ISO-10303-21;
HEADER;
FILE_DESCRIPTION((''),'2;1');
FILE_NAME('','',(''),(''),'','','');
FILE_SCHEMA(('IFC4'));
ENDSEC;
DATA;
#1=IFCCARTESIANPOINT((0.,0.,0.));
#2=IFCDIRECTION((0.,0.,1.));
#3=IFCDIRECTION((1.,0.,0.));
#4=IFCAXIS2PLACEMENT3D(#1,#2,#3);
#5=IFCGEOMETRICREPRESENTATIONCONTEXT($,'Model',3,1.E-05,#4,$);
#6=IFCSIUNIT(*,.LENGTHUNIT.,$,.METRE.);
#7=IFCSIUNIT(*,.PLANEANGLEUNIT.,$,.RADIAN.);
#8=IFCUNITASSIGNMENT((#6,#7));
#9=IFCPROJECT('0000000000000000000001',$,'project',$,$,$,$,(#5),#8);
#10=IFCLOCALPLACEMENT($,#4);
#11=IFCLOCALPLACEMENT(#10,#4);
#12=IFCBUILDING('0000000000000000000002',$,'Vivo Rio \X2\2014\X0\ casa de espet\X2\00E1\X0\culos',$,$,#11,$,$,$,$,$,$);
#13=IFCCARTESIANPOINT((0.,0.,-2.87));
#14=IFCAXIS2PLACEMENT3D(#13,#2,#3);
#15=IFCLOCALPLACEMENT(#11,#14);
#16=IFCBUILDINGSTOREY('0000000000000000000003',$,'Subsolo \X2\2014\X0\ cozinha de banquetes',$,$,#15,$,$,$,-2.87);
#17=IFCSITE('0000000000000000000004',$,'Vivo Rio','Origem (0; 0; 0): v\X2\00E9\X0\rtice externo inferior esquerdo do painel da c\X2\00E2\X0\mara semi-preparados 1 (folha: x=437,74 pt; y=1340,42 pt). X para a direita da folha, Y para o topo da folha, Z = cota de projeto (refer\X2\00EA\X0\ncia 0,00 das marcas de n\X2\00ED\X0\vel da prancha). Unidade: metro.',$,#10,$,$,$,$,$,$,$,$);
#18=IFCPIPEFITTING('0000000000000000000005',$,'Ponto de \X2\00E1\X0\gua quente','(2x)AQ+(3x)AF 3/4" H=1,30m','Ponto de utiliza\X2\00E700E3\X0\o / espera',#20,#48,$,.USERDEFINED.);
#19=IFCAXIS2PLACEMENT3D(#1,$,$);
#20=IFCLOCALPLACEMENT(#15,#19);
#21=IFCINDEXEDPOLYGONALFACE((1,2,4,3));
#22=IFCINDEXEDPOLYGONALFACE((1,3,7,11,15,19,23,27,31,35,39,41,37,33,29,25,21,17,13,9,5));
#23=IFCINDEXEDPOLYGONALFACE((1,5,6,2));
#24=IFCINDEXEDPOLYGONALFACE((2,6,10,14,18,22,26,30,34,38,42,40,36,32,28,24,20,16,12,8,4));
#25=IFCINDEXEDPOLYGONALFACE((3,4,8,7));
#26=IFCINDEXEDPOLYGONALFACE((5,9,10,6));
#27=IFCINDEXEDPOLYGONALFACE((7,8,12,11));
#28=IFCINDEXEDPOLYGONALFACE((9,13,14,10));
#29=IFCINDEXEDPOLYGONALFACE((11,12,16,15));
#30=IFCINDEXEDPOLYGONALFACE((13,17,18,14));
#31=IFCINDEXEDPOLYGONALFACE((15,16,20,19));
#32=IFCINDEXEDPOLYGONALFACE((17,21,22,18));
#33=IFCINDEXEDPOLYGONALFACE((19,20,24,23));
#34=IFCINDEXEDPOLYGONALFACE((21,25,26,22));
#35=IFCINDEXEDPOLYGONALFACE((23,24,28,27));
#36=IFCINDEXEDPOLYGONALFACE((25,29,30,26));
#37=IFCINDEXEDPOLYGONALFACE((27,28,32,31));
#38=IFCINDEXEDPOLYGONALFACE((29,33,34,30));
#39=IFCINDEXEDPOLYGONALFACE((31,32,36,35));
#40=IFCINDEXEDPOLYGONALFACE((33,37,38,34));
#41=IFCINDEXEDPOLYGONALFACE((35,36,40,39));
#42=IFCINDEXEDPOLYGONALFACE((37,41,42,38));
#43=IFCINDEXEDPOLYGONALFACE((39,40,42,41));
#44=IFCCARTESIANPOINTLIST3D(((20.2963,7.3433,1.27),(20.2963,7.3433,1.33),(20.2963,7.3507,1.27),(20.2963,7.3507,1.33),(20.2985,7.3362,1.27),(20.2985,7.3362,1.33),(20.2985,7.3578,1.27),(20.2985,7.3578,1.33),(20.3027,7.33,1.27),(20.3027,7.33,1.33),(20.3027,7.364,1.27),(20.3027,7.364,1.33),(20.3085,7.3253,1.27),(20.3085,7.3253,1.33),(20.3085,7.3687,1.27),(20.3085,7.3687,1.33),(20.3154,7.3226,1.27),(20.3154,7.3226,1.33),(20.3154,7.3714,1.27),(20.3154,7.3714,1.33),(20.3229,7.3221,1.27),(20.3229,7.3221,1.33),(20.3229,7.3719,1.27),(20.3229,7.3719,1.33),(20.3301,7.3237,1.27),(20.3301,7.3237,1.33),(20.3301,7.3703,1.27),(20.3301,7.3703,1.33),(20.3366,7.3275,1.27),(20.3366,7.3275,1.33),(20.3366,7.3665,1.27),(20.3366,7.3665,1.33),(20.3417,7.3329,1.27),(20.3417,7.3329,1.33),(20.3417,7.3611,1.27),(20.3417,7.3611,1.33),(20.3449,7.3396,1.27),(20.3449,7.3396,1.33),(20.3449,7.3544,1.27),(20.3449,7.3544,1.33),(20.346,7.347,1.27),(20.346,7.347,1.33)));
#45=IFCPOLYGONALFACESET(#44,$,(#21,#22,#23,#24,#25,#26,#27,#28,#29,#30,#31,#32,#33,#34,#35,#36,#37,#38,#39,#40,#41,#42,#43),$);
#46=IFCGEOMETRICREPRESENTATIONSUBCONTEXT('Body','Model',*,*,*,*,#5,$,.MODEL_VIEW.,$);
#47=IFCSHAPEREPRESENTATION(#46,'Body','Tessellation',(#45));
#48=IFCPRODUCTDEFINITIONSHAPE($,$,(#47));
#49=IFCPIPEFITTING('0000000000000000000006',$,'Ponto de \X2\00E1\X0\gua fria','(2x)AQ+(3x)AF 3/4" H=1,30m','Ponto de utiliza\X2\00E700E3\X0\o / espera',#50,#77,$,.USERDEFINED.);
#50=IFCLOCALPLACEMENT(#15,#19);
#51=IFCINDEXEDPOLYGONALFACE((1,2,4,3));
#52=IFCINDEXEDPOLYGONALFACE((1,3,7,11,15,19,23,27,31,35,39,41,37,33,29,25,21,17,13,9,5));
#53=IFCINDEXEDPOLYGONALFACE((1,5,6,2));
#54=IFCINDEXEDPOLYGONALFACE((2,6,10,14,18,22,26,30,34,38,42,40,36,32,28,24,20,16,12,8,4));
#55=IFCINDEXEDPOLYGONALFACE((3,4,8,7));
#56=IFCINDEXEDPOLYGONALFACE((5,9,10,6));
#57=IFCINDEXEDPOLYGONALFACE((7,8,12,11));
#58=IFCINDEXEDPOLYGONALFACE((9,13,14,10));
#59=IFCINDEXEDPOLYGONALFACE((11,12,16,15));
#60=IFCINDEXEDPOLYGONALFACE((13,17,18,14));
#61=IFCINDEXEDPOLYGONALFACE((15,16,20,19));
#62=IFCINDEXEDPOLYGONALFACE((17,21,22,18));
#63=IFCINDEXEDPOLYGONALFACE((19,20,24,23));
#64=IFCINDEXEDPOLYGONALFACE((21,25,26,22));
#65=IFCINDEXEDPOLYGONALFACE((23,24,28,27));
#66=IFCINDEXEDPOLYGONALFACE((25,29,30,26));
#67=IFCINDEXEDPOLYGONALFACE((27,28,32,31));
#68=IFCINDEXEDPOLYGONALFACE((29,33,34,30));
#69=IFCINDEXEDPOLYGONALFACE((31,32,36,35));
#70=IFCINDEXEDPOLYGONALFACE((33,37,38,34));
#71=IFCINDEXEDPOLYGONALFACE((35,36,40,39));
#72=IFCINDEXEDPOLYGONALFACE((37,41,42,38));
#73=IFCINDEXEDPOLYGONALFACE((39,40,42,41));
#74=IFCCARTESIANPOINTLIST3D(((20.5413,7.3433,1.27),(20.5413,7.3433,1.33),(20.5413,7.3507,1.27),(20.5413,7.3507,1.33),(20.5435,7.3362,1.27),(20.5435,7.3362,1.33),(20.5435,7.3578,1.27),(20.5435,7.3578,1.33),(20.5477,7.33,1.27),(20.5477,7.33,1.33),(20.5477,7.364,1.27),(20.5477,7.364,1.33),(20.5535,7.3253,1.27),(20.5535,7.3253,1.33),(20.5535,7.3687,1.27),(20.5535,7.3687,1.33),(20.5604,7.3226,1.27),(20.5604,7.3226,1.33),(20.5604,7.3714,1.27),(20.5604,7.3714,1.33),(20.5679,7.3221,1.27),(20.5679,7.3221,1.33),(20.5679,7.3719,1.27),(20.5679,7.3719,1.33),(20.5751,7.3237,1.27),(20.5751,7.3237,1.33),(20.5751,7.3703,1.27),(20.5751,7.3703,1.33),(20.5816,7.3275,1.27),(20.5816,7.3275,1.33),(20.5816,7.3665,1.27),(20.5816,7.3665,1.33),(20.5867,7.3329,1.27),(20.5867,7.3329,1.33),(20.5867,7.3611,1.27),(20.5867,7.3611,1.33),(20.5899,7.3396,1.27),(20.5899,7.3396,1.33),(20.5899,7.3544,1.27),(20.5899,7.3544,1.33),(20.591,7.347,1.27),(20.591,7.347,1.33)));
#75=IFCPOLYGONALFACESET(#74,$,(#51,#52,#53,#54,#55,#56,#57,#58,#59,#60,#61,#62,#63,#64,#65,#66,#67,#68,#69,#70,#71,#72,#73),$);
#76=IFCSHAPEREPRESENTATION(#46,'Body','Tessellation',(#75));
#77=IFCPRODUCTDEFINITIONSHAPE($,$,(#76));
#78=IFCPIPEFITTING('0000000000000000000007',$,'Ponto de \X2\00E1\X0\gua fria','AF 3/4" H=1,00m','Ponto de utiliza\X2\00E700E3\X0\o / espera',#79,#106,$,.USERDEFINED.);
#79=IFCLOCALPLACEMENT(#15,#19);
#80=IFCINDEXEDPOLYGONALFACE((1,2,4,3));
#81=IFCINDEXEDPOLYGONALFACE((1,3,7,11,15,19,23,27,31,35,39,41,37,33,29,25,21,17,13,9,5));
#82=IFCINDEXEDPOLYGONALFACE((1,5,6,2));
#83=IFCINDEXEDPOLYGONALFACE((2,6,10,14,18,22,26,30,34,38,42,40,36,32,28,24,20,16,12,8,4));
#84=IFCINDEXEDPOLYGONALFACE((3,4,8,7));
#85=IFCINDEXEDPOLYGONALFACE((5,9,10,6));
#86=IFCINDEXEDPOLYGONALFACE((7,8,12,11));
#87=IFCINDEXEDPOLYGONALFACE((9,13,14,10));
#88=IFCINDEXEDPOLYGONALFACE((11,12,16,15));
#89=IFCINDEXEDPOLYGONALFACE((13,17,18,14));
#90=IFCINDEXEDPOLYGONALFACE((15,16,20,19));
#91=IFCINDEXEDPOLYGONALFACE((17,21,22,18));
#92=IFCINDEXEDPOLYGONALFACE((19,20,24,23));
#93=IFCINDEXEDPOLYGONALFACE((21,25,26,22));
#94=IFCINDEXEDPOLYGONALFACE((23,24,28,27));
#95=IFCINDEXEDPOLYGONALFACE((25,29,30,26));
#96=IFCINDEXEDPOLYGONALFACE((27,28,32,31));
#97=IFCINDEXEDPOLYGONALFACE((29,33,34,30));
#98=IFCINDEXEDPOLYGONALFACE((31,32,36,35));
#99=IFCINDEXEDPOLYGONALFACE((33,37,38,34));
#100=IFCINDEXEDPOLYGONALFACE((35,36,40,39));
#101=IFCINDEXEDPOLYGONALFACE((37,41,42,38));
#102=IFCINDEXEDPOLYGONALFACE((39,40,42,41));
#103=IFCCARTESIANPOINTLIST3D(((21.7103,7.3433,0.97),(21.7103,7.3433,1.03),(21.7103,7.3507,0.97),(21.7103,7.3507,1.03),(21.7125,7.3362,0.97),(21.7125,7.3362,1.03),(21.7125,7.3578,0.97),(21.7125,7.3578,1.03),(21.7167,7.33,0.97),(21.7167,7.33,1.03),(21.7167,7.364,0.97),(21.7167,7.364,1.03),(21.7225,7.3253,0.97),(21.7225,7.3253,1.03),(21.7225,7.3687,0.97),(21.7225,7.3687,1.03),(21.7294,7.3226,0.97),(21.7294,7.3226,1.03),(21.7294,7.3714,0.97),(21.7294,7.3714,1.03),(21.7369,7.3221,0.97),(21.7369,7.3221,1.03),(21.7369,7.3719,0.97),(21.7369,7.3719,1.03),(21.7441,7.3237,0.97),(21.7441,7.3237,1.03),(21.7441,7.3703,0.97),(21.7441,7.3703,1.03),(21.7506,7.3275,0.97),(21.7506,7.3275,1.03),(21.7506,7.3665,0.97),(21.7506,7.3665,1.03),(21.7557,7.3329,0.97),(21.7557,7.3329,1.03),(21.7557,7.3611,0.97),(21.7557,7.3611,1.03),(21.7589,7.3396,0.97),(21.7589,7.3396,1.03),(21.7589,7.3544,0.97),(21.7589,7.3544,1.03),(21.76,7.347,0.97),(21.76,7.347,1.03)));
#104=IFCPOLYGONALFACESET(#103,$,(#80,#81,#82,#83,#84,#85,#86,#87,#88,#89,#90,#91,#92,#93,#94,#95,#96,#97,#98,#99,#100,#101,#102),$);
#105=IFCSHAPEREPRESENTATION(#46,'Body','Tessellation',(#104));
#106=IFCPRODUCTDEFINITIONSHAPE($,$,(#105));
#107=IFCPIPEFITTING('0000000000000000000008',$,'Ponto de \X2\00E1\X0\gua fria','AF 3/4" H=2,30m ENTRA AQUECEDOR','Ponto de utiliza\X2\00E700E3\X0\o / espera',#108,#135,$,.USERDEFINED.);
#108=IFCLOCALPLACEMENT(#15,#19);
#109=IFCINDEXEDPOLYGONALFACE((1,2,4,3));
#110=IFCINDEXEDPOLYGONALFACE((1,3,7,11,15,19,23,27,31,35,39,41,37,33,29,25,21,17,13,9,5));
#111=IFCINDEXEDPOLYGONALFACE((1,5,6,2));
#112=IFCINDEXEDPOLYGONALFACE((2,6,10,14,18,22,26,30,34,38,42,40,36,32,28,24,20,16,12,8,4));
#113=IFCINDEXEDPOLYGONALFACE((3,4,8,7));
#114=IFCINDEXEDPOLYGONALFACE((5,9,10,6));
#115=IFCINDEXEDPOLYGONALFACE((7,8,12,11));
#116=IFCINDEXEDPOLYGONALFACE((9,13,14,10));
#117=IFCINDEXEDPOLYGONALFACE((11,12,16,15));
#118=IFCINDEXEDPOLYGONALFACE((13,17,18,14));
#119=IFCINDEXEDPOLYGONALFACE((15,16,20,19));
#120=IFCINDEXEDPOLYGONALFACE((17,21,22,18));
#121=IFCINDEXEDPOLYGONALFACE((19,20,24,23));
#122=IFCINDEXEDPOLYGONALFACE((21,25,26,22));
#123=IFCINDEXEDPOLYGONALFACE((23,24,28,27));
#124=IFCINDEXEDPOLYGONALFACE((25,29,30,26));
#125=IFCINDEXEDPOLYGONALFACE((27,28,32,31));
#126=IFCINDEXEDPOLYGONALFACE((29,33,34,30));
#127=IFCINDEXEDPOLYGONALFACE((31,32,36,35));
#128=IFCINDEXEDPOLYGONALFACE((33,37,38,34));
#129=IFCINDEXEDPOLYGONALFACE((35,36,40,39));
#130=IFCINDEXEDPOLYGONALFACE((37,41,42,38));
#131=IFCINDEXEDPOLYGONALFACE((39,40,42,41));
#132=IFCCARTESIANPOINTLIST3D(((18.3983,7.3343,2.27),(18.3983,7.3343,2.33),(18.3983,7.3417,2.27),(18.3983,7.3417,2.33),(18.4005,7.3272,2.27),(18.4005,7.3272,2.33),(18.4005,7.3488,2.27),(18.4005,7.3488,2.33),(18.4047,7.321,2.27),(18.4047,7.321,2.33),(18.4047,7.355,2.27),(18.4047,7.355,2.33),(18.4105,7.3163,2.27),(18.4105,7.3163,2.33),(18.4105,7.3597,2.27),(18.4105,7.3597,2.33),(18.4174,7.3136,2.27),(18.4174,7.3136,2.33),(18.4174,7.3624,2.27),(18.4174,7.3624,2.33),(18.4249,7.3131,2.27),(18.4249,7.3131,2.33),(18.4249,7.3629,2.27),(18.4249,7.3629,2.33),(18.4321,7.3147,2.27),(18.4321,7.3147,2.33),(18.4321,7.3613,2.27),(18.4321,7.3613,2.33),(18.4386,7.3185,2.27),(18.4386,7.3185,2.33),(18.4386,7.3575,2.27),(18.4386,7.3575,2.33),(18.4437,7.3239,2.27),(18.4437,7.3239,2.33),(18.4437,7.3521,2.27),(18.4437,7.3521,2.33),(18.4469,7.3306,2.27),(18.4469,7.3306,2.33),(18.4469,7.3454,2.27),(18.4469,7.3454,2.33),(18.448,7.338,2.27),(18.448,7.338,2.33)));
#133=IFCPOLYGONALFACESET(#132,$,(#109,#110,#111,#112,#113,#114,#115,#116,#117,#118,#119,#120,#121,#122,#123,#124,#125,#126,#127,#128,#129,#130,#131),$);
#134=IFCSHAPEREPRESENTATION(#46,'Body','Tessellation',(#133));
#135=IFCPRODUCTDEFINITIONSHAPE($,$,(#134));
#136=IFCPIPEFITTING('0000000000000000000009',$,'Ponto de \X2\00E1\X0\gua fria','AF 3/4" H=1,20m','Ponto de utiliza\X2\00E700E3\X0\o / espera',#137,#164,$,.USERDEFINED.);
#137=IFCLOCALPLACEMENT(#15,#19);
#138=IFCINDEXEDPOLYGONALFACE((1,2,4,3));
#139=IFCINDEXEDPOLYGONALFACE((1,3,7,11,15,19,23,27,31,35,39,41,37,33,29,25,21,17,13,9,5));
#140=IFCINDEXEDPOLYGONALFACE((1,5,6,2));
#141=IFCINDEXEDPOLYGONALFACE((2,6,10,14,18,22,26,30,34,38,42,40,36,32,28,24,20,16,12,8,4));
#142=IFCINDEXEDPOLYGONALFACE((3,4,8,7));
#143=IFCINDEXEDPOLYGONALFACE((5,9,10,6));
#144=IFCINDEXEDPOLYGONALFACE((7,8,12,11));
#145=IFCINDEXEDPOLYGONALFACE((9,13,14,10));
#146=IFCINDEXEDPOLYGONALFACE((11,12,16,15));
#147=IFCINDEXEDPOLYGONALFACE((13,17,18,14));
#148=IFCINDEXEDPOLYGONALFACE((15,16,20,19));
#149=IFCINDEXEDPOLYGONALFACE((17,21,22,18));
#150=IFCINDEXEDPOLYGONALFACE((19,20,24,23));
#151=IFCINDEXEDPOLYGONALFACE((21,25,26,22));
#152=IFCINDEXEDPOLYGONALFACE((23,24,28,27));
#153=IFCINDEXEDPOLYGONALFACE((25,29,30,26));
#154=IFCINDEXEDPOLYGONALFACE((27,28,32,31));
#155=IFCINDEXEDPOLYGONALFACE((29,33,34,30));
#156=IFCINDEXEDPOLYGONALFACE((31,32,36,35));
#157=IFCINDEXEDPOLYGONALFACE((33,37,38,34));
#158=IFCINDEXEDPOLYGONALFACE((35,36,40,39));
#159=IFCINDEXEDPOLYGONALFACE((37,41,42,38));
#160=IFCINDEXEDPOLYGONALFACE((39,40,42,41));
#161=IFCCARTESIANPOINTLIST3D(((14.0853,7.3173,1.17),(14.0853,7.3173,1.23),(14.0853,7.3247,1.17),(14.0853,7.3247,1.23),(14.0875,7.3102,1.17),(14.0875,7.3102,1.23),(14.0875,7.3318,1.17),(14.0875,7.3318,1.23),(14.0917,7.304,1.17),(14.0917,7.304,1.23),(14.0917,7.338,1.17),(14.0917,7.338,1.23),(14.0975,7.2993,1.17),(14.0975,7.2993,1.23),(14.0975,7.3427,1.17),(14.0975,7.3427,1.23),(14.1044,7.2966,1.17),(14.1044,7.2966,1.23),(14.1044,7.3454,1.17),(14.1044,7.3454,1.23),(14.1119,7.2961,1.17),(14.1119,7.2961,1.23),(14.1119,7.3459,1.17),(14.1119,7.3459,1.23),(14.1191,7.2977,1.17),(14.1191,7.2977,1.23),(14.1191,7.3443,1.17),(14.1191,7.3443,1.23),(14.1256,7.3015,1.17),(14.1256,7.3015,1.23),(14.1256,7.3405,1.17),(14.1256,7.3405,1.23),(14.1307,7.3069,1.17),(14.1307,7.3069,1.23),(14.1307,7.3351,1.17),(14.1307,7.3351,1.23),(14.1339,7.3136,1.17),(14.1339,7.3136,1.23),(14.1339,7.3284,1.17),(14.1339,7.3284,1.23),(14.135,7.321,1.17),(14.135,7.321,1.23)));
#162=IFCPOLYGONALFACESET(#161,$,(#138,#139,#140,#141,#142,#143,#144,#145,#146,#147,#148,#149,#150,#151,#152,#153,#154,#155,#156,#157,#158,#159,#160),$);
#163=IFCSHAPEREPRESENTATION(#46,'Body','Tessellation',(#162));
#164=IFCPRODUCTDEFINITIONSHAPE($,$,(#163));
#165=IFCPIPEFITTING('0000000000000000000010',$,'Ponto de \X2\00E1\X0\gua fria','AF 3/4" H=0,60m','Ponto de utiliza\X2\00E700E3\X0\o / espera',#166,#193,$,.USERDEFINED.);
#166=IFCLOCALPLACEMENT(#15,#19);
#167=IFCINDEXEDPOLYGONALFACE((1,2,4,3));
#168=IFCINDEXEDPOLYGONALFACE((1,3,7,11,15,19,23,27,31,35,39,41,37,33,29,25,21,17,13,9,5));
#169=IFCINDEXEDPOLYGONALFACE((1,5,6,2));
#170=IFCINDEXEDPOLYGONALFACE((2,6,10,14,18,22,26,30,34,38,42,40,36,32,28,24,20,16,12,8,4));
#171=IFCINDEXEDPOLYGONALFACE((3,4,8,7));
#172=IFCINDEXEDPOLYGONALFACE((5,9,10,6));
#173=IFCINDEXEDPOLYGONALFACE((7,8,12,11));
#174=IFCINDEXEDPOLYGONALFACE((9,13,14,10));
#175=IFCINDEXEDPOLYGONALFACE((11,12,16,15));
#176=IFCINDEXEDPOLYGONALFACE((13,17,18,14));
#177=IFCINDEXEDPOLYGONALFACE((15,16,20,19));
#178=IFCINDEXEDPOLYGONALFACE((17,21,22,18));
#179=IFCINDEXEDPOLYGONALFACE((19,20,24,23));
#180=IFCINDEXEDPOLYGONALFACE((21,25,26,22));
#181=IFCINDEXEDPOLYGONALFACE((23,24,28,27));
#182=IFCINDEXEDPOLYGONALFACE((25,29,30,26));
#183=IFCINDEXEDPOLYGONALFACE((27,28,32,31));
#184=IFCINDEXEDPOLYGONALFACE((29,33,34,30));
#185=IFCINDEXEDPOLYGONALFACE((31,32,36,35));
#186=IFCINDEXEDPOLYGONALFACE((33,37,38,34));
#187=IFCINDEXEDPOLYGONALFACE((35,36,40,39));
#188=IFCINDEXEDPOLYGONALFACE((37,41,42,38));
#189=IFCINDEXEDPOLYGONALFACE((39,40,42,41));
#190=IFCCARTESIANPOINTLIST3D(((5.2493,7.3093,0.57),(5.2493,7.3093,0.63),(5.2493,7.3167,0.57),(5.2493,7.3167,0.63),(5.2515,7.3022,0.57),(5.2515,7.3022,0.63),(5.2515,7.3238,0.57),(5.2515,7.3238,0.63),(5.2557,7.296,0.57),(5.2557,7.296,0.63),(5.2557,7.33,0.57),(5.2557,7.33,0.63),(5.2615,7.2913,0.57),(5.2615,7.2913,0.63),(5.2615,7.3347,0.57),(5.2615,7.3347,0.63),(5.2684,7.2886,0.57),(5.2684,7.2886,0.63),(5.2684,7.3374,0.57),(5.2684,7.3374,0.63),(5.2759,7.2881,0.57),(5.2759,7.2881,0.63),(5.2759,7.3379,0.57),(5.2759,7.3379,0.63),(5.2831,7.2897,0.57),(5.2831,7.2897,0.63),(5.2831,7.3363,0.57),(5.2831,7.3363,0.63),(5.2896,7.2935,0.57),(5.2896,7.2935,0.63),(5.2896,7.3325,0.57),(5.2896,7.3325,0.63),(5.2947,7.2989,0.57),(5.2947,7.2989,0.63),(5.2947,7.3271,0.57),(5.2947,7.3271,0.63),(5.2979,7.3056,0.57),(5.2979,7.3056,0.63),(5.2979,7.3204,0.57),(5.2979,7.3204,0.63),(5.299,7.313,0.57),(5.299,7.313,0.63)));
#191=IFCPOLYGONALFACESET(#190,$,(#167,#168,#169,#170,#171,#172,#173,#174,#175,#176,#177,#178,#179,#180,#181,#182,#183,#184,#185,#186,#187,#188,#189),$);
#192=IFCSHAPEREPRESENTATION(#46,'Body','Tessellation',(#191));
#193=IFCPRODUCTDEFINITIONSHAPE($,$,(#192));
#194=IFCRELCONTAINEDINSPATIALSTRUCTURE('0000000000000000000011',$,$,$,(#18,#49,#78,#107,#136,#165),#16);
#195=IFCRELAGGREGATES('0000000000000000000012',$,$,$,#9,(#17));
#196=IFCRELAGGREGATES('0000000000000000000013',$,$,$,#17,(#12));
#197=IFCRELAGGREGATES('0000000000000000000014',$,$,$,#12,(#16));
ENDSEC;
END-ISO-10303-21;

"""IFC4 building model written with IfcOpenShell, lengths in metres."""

from ifc_helpers import new_model, si_unit, frame, origin_with_axes, origin_2d, place, context, subcontext, project, spatial, circle, extrude, element, save


model = new_model("IFC4")

# Units and contexts
model_context = context("Model", 3, precision=1e-05, world=origin_with_axes())
body_context = subcontext(model_context, "Body", "Model", "MODEL_VIEW")
ifc_project = project(units=[si_unit("LENGTHUNIT", "METRE"), si_unit("PLANEANGLEUNIT", "RADIAN")], contexts=[model_context])

# Site, building, storey
site_placement = place(None, origin_with_axes())
site = spatial("IfcSite", under=ifc_project, at=site_placement, Name="Vivo Rio", Description="Origem (0; 0; 0): vértice externo inferior esquerdo do painel da câmara semi-preparados 1 (folha: x=437,74 pt; y=1340,42 pt). X para a direita da folha, Y para o topo da folha, Z = cota de projeto (referência 0,00 das marcas de nível da prancha). Unidade: metro.")
building_placement = place(site_placement, origin_with_axes())
building = spatial("IfcBuilding", under=site, at=building_placement, Name="Vivo Rio — casa de espetáculos")
storey_placement = place(building_placement, frame((0.0, 0.0, -2.87), z_axis=(0.0, 0.0, 1.0), x_axis=(1.0, 0.0, 0.0)))
storey = spatial("IfcBuildingStorey", under=building, at=storey_placement, Name="Subsolo — cozinha de banquetes", Elevation=-2.87)

# Pipe fittings
pipe_fitting_1_placement = place(storey_placement, origin_with_axes())
element("IfcPipeFitting", 1, at=pipe_fitting_1_placement, inside=storey, Name="Ponto de água quente", Description="(2x)AQ+(3x)AF 3/4\" H=1,30m", ObjectType="Ponto de utilização / espera", PredefinedType="USERDEFINED", context=body_context, shape_type="SweptSolid", body=[
    extrude(circle(Radius=0.025, at=origin_2d()), frame((20.321, 7.347, 1.27), z_axis=(0.0, 0.0, 1.0), x_axis=(1.0, 0.0, 0.0)), (0.0, 0.0, 1.0), 0.06),
])
pipe_fitting_2_placement = place(storey_placement, origin_with_axes())
element("IfcPipeFitting", 2, at=pipe_fitting_2_placement, inside=storey, Name="Ponto de água fria", Description="(2x)AQ+(3x)AF 3/4\" H=1,30m", ObjectType="Ponto de utilização / espera", PredefinedType="USERDEFINED", context=body_context, shape_type="SweptSolid", body=[
    extrude(circle(Radius=0.025, at=origin_2d()), frame((20.566, 7.347, 1.27), z_axis=(0.0, 0.0, 1.0), x_axis=(1.0, 0.0, 0.0)), (0.0, 0.0, 1.0), 0.06),
])
pipe_fitting_3_placement = place(storey_placement, origin_with_axes())
element("IfcPipeFitting", 3, at=pipe_fitting_3_placement, inside=storey, Name="Ponto de água fria", Description="AF 3/4\" H=1,00m", ObjectType="Ponto de utilização / espera", PredefinedType="USERDEFINED", context=body_context, shape_type="SweptSolid", body=[
    extrude(circle(Radius=0.025, at=origin_2d()), frame((21.735, 7.347, 0.97), z_axis=(0.0, 0.0, 1.0), x_axis=(1.0, 0.0, 0.0)), (0.0, 0.0, 1.0), 0.06),
])
pipe_fitting_4_placement = place(storey_placement, origin_with_axes())
element("IfcPipeFitting", 4, at=pipe_fitting_4_placement, inside=storey, Name="Ponto de água fria", Description="AF 3/4\" H=2,30m ENTRA AQUECEDOR", ObjectType="Ponto de utilização / espera", PredefinedType="USERDEFINED", context=body_context, shape_type="SweptSolid", body=[
    extrude(circle(Radius=0.025, at=origin_2d()), frame((18.423, 7.338, 2.27), z_axis=(0.0, 0.0, 1.0), x_axis=(1.0, 0.0, 0.0)), (0.0, 0.0, 1.0), 0.06),
])
pipe_fitting_5_placement = place(storey_placement, origin_with_axes())
element("IfcPipeFitting", 5, at=pipe_fitting_5_placement, inside=storey, Name="Ponto de água fria", Description="AF 3/4\" H=1,20m", ObjectType="Ponto de utilização / espera", PredefinedType="USERDEFINED", context=body_context, shape_type="SweptSolid", body=[
    extrude(circle(Radius=0.025, at=origin_2d()), frame((14.11, 7.321, 1.17), z_axis=(0.0, 0.0, 1.0), x_axis=(1.0, 0.0, 0.0)), (0.0, 0.0, 1.0), 0.06),
])
pipe_fitting_6_placement = place(storey_placement, origin_with_axes())
element("IfcPipeFitting", 6, at=pipe_fitting_6_placement, inside=storey, Name="Ponto de água fria", Description="AF 3/4\" H=0,60m", ObjectType="Ponto de utilização / espera", PredefinedType="USERDEFINED", context=body_context, shape_type="SweptSolid", body=[
    extrude(circle(Radius=0.025, at=origin_2d()), frame((5.274, 7.313, 0.57), z_axis=(0.0, 0.0, 1.0), x_axis=(1.0, 0.0, 0.0)), (0.0, 0.0, 1.0), 0.06),
])

save(model, "model.ifc")
